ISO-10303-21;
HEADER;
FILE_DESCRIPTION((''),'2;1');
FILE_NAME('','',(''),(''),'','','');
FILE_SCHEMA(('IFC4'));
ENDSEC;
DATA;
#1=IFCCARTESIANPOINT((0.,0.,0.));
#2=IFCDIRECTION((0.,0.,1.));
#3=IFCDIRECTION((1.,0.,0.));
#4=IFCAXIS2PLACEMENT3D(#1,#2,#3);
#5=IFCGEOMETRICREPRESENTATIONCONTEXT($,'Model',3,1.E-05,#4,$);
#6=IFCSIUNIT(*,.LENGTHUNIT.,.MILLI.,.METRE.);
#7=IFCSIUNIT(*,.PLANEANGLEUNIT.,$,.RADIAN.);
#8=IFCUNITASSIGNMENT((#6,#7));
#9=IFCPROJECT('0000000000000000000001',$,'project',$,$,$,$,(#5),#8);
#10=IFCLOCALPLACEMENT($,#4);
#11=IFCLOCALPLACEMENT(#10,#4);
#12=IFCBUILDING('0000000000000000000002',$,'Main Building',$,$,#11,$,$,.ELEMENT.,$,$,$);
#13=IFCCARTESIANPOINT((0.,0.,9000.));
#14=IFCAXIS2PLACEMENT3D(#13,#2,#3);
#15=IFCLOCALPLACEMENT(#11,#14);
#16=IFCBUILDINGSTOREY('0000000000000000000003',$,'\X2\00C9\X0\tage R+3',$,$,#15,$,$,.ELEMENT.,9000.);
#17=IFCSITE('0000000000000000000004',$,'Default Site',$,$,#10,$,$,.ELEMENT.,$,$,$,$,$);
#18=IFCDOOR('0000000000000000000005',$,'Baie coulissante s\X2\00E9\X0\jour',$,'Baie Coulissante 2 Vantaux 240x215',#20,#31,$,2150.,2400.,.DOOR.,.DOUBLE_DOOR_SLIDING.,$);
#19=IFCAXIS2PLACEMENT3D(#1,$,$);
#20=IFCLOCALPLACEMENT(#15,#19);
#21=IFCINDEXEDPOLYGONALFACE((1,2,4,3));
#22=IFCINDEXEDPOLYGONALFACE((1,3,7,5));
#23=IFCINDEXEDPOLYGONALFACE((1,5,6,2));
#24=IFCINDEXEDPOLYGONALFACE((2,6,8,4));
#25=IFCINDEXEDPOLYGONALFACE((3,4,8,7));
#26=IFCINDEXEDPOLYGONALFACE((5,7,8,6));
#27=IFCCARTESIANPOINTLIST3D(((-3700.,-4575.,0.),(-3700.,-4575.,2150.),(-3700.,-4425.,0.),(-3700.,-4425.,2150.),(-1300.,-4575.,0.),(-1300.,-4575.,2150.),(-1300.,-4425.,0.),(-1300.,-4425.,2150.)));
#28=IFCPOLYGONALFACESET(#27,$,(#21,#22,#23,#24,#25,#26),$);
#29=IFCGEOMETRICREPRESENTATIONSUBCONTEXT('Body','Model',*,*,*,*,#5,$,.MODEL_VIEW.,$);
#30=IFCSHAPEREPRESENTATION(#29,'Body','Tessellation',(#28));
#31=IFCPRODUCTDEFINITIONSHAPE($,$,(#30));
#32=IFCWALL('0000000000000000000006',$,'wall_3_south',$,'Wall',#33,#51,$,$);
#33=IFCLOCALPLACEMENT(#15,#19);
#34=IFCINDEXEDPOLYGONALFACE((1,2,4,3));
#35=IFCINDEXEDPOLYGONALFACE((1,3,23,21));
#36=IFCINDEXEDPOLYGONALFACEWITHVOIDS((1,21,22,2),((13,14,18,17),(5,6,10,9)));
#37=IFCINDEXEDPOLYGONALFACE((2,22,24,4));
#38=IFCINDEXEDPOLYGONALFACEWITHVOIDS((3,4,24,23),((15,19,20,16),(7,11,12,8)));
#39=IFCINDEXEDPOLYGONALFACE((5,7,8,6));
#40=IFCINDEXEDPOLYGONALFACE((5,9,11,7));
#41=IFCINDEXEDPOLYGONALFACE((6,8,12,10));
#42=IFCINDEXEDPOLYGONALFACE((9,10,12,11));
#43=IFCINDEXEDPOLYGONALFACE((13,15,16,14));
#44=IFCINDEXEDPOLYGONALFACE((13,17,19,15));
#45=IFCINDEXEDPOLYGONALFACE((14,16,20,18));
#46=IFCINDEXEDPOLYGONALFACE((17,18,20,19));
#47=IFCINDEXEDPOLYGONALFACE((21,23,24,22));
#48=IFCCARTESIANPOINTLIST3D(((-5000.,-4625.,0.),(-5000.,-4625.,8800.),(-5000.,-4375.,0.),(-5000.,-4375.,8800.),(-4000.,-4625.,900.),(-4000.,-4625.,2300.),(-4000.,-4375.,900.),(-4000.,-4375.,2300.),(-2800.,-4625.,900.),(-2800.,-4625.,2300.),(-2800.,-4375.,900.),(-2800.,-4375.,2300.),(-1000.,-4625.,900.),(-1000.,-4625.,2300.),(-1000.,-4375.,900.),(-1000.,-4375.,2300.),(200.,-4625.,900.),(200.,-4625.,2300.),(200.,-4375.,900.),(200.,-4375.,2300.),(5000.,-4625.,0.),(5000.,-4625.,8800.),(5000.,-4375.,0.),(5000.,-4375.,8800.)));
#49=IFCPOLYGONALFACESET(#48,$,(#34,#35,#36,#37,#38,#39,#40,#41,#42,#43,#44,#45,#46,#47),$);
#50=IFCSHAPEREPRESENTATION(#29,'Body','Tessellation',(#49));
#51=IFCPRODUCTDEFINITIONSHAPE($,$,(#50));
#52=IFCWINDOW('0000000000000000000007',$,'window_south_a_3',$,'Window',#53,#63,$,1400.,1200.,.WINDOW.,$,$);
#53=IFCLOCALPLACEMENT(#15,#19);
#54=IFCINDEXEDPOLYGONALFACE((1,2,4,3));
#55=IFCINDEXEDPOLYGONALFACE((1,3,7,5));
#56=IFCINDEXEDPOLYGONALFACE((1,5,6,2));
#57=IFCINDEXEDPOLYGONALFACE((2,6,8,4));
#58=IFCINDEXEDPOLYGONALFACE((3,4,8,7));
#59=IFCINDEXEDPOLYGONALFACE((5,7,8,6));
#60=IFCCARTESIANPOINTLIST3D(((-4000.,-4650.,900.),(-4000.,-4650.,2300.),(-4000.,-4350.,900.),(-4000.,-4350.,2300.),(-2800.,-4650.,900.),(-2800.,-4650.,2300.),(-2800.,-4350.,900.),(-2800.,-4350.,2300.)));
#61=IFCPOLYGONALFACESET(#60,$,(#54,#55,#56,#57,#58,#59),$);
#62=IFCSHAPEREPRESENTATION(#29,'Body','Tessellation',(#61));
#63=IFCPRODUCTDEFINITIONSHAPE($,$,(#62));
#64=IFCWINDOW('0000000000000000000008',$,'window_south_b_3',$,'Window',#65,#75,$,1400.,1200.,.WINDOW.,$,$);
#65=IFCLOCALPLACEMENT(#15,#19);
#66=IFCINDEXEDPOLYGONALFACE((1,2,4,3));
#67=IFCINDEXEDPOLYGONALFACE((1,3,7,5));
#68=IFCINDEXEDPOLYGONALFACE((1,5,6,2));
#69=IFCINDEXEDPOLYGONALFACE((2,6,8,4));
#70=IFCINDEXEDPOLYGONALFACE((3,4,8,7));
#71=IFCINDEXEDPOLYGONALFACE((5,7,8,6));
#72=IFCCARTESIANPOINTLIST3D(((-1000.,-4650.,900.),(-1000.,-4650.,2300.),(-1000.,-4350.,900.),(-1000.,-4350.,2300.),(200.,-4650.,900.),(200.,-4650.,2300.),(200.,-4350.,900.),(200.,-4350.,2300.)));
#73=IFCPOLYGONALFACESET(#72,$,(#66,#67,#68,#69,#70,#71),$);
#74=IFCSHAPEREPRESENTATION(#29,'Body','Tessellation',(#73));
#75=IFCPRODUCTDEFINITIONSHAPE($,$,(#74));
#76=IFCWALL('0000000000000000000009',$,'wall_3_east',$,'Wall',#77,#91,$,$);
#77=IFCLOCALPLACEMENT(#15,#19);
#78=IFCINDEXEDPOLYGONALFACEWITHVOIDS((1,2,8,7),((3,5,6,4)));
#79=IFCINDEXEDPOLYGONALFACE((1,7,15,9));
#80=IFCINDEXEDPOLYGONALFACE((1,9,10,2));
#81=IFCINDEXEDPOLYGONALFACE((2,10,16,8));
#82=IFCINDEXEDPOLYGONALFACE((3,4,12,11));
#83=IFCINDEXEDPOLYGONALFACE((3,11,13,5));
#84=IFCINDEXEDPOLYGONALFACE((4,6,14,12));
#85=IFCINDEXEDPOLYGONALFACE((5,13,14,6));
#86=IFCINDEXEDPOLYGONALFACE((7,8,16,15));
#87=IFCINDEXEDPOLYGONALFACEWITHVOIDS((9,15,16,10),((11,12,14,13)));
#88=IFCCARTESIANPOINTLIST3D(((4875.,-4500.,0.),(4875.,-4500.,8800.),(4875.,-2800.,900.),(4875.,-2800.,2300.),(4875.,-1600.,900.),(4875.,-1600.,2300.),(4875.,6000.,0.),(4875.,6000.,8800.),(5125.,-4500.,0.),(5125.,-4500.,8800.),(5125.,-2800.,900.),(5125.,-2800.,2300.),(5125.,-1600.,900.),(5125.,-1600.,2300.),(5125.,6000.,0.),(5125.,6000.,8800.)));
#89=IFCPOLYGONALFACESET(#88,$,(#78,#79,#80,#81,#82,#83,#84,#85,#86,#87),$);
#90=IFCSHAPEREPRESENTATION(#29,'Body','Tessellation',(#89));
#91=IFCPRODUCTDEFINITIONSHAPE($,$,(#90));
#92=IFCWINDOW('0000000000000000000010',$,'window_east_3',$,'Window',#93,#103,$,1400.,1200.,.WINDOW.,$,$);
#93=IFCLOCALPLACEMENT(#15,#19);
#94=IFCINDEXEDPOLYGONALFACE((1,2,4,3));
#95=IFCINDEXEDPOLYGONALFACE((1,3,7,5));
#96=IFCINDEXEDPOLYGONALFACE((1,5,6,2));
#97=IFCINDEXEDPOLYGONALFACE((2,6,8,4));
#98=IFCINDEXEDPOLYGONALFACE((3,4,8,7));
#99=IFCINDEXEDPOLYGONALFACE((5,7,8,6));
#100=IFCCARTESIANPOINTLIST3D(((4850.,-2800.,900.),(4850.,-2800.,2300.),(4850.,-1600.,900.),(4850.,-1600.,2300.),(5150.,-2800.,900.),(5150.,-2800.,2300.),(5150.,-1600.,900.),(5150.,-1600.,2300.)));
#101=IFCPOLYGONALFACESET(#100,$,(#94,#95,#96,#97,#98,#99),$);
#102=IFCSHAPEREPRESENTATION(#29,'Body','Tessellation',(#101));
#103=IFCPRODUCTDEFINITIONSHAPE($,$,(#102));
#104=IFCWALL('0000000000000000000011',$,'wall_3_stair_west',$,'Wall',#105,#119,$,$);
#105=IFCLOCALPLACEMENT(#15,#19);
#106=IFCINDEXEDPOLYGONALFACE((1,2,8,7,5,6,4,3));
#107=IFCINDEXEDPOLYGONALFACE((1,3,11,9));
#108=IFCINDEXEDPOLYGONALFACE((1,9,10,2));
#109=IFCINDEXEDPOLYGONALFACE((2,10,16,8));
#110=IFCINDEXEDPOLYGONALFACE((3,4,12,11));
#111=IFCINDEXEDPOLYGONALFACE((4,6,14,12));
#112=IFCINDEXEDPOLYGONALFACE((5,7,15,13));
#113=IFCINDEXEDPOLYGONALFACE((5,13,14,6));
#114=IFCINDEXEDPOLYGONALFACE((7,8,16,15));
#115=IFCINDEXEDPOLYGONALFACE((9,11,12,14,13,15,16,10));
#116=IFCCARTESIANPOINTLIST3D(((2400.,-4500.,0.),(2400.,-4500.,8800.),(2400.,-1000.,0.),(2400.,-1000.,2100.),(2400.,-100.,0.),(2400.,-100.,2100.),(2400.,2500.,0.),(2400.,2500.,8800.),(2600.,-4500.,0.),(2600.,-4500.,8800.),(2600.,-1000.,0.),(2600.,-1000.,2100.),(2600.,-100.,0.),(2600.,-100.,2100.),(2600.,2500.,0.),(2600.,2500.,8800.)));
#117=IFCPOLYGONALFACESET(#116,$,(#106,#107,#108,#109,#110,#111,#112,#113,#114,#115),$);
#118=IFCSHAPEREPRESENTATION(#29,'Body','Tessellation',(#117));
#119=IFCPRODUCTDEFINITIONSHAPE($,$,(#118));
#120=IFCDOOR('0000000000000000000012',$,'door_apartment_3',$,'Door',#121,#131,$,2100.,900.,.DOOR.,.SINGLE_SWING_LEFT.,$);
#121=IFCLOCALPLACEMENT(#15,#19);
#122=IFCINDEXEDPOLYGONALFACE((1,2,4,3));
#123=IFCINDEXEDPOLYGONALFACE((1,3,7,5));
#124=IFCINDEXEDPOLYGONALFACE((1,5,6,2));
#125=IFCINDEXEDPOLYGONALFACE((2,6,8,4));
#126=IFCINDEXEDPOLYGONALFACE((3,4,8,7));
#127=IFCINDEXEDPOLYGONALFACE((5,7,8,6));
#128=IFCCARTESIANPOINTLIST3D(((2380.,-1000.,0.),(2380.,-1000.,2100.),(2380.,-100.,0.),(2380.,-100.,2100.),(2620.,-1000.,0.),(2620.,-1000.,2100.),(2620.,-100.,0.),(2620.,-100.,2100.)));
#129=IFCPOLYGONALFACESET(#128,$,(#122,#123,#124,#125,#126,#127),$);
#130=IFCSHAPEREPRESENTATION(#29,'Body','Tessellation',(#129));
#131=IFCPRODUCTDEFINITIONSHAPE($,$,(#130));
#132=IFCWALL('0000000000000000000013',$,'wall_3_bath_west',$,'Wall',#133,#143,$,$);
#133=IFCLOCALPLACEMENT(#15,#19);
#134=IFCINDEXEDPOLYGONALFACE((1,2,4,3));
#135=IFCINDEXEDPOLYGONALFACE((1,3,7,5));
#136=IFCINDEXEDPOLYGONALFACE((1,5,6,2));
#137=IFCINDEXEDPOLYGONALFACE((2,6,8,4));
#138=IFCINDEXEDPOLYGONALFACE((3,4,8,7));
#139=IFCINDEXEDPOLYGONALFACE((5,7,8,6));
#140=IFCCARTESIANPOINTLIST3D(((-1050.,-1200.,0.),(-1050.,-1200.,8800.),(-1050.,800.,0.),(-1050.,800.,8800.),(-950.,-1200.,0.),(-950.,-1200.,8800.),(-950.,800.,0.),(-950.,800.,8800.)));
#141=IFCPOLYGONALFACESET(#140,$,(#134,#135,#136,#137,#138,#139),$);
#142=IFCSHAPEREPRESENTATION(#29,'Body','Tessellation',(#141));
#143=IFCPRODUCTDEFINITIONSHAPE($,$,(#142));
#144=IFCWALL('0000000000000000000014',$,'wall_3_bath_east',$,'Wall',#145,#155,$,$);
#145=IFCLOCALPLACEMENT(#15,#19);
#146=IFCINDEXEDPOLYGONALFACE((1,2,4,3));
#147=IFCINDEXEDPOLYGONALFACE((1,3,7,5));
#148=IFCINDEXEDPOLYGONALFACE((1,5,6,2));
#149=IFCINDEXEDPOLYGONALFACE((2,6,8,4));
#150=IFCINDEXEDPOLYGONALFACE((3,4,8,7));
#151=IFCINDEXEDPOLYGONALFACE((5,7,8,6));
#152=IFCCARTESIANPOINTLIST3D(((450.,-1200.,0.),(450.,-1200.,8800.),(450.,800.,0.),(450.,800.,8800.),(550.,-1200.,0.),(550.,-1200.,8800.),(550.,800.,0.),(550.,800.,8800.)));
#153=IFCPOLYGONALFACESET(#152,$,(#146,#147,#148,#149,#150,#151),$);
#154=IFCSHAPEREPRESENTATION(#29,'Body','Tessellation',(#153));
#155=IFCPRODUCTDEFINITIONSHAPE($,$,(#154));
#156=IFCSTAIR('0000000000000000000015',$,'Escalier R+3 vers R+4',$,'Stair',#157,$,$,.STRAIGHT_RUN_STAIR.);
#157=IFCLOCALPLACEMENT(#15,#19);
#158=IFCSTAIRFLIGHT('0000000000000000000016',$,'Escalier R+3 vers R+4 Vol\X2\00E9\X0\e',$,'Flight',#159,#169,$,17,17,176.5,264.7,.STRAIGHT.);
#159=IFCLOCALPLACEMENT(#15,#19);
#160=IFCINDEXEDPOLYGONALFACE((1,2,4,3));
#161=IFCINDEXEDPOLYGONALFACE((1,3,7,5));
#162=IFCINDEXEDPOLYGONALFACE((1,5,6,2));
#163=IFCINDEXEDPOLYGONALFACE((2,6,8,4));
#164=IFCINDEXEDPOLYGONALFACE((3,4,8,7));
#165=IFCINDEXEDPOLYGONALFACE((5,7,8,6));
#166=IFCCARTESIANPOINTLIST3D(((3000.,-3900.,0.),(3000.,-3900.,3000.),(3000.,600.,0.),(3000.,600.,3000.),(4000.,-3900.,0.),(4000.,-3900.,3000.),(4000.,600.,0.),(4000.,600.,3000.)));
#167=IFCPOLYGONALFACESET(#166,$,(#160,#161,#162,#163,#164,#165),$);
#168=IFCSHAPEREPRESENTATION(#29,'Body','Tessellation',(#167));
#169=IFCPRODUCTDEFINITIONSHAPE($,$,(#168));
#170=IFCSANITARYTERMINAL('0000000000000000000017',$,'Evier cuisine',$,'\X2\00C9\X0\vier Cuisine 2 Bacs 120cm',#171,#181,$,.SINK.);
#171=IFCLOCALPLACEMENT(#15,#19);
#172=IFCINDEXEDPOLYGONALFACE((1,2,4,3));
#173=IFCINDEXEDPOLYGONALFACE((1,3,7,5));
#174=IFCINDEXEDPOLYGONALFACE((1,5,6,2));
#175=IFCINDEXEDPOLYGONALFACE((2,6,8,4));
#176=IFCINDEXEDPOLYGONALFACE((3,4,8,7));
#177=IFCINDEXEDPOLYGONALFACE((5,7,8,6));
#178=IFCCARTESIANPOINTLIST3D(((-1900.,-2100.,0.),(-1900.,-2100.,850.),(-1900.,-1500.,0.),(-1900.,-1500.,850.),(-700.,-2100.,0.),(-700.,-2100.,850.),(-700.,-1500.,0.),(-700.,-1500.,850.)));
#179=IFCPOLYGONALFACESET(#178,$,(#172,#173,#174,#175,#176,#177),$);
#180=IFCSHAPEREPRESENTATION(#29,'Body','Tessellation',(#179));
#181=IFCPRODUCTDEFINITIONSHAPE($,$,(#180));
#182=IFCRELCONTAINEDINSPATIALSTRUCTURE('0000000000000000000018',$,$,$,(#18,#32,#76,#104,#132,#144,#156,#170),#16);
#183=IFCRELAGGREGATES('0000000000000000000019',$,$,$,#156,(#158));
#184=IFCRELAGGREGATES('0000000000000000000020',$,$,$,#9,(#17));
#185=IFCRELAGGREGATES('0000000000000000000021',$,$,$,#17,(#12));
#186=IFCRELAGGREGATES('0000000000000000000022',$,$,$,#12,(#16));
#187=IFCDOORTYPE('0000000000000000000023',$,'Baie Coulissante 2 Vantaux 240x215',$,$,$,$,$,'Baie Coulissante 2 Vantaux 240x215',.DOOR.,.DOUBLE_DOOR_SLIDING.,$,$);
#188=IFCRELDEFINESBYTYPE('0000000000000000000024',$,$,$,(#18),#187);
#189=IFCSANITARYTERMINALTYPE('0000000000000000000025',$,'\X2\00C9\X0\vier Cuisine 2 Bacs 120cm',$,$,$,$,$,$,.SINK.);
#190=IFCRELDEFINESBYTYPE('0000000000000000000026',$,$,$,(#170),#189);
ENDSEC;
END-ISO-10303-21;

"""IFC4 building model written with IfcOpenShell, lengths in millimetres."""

from ifc_helpers import new_model, si_unit, frame, origin_with_axes, place, context, subcontext, project, spatial, polyline, outline, extrude, type_object, element, fill, aggregate, save


model = new_model("IFC4")

# Units and contexts
model_context = context("Model", 3, precision=1e-05, world=origin_with_axes())
body_context = subcontext(model_context, "Body", "Model", "MODEL_VIEW")
ifc_project = project(units=[si_unit("LENGTHUNIT", "METRE", prefix="MILLI"), si_unit("PLANEANGLEUNIT", "RADIAN")], contexts=[model_context])

# Site, building, storey
site_placement = place(None, origin_with_axes())
site = spatial("IfcSite", under=ifc_project, at=site_placement, Name="Default Site", CompositionType="ELEMENT")
building_placement = place(site_placement, origin_with_axes())
building = spatial("IfcBuilding", under=site, at=building_placement, Name="Main Building", CompositionType="ELEMENT")
storey_placement = place(building_placement, frame((0.0, 0.0, 9000.0), z_axis=(0.0, 0.0, 1.0), x_axis=(1.0, 0.0, 0.0)))
storey = spatial("IfcBuildingStorey", under=building, at=storey_placement, Name="Étage R+3", CompositionType="ELEMENT", Elevation=9000.0)

# Door
door_type = type_object("IfcDoorType", Name="Baie Coulissante 2 Vantaux 240x215", ElementType="Baie Coulissante 2 Vantaux 240x215", OperationType="DOUBLE_DOOR_SLIDING", PredefinedType="DOOR")
door_1_placement = place(storey_placement, frame((-2500.0, -4500.0, 0.0), z_axis=(0.0, 0.0, 1.0), x_axis=(1.0, 0.0, 0.0)))
element("IfcDoor", 1, at=door_1_placement, inside=storey, type_object=door_type, Name="Baie coulissante séjour", ObjectType="Baie Coulissante 2 Vantaux 240x215", OperationType="DOUBLE_DOOR_SLIDING", OverallHeight=2150.0, OverallWidth=2400.0, PredefinedType="DOOR", context=body_context, shape_type="SweptSolid", body=[
    extrude(outline(polyline([(-1200.0, -75.0), (1200.0, -75.0), (1200.0, 75.0), (-1200.0, 75.0), (-1200.0, -75.0)])), origin_with_axes(), (0.0, 0.0, 1.0), 2150.0),
])

# Wall, openings, windows
wall_1_placement = place(storey_placement, frame((-5000.0, -4500.0, 0.0), z_axis=(0.0, 0.0, 1.0), x_axis=(1.0, 0.0, 0.0)))
wall_1 = element("IfcWall", 2, at=wall_1_placement, inside=storey, Name="wall_3_south", ObjectType="Wall", context=body_context, shape_type="SweptSolid", body=[
    extrude(outline(polyline([(0.0, -125.0), (10000.0, -125.0), (10000.0, 125.0), (0.0, 125.0), (0.0, -125.0)])), origin_with_axes(), (0.0, 0.0, 1.0), 8800.0),
])
placement_1 = place(wall_1_placement, frame((1000.0, 0.0, 900.0), z_axis=(0.0, 0.0, 1.0), x_axis=(1.0, 0.0, 0.0)))
opening_1 = element("IfcOpeningElement", 3, at=placement_1, cuts=wall_1, PredefinedType="OPENING", context=body_context, shape_type="SweptSolid", body=[
    extrude(outline(polyline([(0.0, -150.0), (1200.0, -150.0), (1200.0, 150.0), (0.0, 150.0), (0.0, -150.0)])), origin_with_axes(), (0.0, 0.0, 1.0), 1400.0),
])
placement_2 = place(wall_1_placement, frame((4000.0, 0.0, 900.0), z_axis=(0.0, 0.0, 1.0), x_axis=(1.0, 0.0, 0.0)))
opening_2 = element("IfcOpeningElement", 4, at=placement_2, cuts=wall_1, PredefinedType="OPENING", context=body_context, shape_type="SweptSolid", body=[
    extrude(outline(polyline([(0.0, -150.0), (1200.0, -150.0), (1200.0, 150.0), (0.0, 150.0), (0.0, -150.0)])), origin_with_axes(), (0.0, 0.0, 1.0), 1400.0),
])
window_1 = element("IfcWindow", 5, at=placement_1, Name="window_south_a_3", ObjectType="Window", OverallHeight=1400.0, OverallWidth=1200.0, PredefinedType="WINDOW", context=body_context, shape_type="SweptSolid", body=[
    extrude(outline(polyline([(0.0, -150.0), (1200.0, -150.0), (1200.0, 150.0), (0.0, 150.0), (0.0, -150.0)])), origin_with_axes(), (0.0, 0.0, 1.0), 1400.0),
])
fill(opening_1, window_1)
window_2 = element("IfcWindow", 6, at=placement_2, Name="window_south_b_3", ObjectType="Window", OverallHeight=1400.0, OverallWidth=1200.0, PredefinedType="WINDOW", context=body_context, shape_type="SweptSolid", body=[
    extrude(outline(polyline([(0.0, -150.0), (1200.0, -150.0), (1200.0, 150.0), (0.0, 150.0), (0.0, -150.0)])), origin_with_axes(), (0.0, 0.0, 1.0), 1400.0),
])
fill(opening_2, window_2)

# Wall, opening, window
wall_2_placement = place(storey_placement, frame((5000.0, -4500.0, 0.0), z_axis=(0.0, 0.0, 1.0), x_axis=(0.0, 1.0, 0.0)))
wall_2 = element("IfcWall", 7, at=wall_2_placement, inside=storey, Name="wall_3_east", ObjectType="Wall", context=body_context, shape_type="SweptSolid", body=[
    extrude(outline(polyline([(0.0, -125.0), (10500.0, -125.0), (10500.0, 125.0), (0.0, 125.0), (0.0, -125.0)])), origin_with_axes(), (0.0, 0.0, 1.0), 8800.0),
])
placement_3 = place(wall_2_placement, frame((1700.0, 0.0, 900.0), z_axis=(0.0, 0.0, 1.0), x_axis=(1.0, 0.0, 0.0)))
opening_3 = element("IfcOpeningElement", 8, at=placement_3, cuts=wall_2, PredefinedType="OPENING", context=body_context, shape_type="SweptSolid", body=[
    extrude(outline(polyline([(0.0, -150.0), (1200.0, -150.0), (1200.0, 150.0), (0.0, 150.0), (0.0, -150.0)])), origin_with_axes(), (0.0, 0.0, 1.0), 1400.0),
])
window_3 = element("IfcWindow", 9, at=placement_3, Name="window_east_3", ObjectType="Window", OverallHeight=1400.0, OverallWidth=1200.0, PredefinedType="WINDOW", context=body_context, shape_type="SweptSolid", body=[
    extrude(outline(polyline([(0.0, -150.0), (1200.0, -150.0), (1200.0, 150.0), (0.0, 150.0), (0.0, -150.0)])), origin_with_axes(), (0.0, 0.0, 1.0), 1400.0),
])
fill(opening_3, window_3)

# Wall, opening, door
wall_3_placement = place(storey_placement, frame((2500.0, -4500.0, 0.0), z_axis=(0.0, 0.0, 1.0), x_axis=(0.0, 1.0, 0.0)))
wall_3 = element("IfcWall", 10, at=wall_3_placement, inside=storey, Name="wall_3_stair_west", ObjectType="Wall", context=body_context, shape_type="SweptSolid", body=[
    extrude(outline(polyline([(0.0, -100.0), (7000.0, -100.0), (7000.0, 100.0), (0.0, 100.0), (0.0, -100.0)])), origin_with_axes(), (0.0, 0.0, 1.0), 8800.0),
])
placement_4 = place(wall_3_placement, frame((3500.0, 0.0, 0.0), z_axis=(0.0, 0.0, 1.0), x_axis=(1.0, 0.0, 0.0)))
opening_4 = element("IfcOpeningElement", 11, at=placement_4, cuts=wall_3, PredefinedType="OPENING", context=body_context, shape_type="SweptSolid", body=[
    extrude(outline(polyline([(0.0, -120.0), (900.0, -120.0), (900.0, 120.0), (0.0, 120.0), (0.0, -120.0)])), origin_with_axes(), (0.0, 0.0, 1.0), 2100.0),
])
door_2 = element("IfcDoor", 12, at=placement_4, Name="door_apartment_3", ObjectType="Door", OperationType="SINGLE_SWING_LEFT", OverallHeight=2100.0, OverallWidth=900.0, PredefinedType="DOOR", context=body_context, shape_type="SweptSolid", body=[
    extrude(outline(polyline([(0.0, -120.0), (900.0, -120.0), (900.0, 120.0), (0.0, 120.0), (0.0, -120.0)])), origin_with_axes(), (0.0, 0.0, 1.0), 2100.0),
])
fill(opening_4, door_2)

# Walls
for number, where, z_axis, x_axis, name in (
    (13, (-1000.0, -1200.0, 0.0), (0.0, 0.0, 1.0), (0.0, 1.0, 0.0), "wall_3_bath_west"),
    (14, (500.0, -1200.0, 0.0), (0.0, 0.0, 1.0), (0.0, 1.0, 0.0), "wall_3_bath_east"),
):
    element("IfcWall", number, at=place(storey_placement, frame(where, z_axis=z_axis, x_axis=x_axis)), inside=storey, Name=name, ObjectType="Wall", context=body_context, shape_type="SweptSolid", body=[
        extrude(outline(polyline([(0.0, -50.0), (2000.0, -50.0), (2000.0, 50.0), (0.0, 50.0), (0.0, -50.0)])), origin_with_axes(), (0.0, 0.0, 1.0), 8800.0),
    ])

# Stair, stair flight
stair_placement = place(storey_placement, frame((3500.0, -3900.0, 0.0), z_axis=(0.0, 0.0, 1.0), x_axis=(0.0, 1.0, 0.0)))
stair = element("IfcStair", 15, at=stair_placement, inside=storey, Name="Escalier R+3 vers R+4", ObjectType="Stair", PredefinedType="STRAIGHT_RUN_STAIR")
stair_flight_placement = place(stair_placement, origin_with_axes())
stair_flight = element("IfcStairFlight", 16, at=stair_flight_placement, Name="Escalier R+3 vers R+4 Volée", ObjectType="Flight", NumberOfRisers=17, NumberOfTreads=17, PredefinedType="STRAIGHT", RiserHeight=176.5, TreadLength=264.7, context=body_context, shape_type="SweptSolid", body=[
    extrude(outline(polyline([(0.0, -500.0), (4500.0, -500.0), (4500.0, 500.0), (0.0, 500.0), (0.0, -500.0)])), origin_with_axes(), (0.0, 0.0, 1.0), 3000.0),
])
aggregate(stair, [stair_flight])

# Sanitary terminal
sanitary_terminal_type = type_object("IfcSanitaryTerminalType", Name="Évier Cuisine 2 Bacs 120cm", PredefinedType="SINK")
sanitary_terminal_placement = place(storey_placement, frame((-1300.0, -1800.0, 0.0), z_axis=(0.0, 0.0, 1.0), x_axis=(1.0, 0.0, 0.0)))
element("IfcSanitaryTerminal", 17, at=sanitary_terminal_placement, inside=storey, type_object=sanitary_terminal_type, Name="Evier cuisine", ObjectType="Évier Cuisine 2 Bacs 120cm", PredefinedType="SINK", context=body_context, shape_type="SweptSolid", body=[
    extrude(outline(polyline([(-600.0, -300.0), (600.0, -300.0), (600.0, 300.0), (-600.0, 300.0), (-600.0, -300.0)])), origin_with_axes(), (0.0, 0.0, 1.0), 850.0),
])

save(model, "model.ifc")
